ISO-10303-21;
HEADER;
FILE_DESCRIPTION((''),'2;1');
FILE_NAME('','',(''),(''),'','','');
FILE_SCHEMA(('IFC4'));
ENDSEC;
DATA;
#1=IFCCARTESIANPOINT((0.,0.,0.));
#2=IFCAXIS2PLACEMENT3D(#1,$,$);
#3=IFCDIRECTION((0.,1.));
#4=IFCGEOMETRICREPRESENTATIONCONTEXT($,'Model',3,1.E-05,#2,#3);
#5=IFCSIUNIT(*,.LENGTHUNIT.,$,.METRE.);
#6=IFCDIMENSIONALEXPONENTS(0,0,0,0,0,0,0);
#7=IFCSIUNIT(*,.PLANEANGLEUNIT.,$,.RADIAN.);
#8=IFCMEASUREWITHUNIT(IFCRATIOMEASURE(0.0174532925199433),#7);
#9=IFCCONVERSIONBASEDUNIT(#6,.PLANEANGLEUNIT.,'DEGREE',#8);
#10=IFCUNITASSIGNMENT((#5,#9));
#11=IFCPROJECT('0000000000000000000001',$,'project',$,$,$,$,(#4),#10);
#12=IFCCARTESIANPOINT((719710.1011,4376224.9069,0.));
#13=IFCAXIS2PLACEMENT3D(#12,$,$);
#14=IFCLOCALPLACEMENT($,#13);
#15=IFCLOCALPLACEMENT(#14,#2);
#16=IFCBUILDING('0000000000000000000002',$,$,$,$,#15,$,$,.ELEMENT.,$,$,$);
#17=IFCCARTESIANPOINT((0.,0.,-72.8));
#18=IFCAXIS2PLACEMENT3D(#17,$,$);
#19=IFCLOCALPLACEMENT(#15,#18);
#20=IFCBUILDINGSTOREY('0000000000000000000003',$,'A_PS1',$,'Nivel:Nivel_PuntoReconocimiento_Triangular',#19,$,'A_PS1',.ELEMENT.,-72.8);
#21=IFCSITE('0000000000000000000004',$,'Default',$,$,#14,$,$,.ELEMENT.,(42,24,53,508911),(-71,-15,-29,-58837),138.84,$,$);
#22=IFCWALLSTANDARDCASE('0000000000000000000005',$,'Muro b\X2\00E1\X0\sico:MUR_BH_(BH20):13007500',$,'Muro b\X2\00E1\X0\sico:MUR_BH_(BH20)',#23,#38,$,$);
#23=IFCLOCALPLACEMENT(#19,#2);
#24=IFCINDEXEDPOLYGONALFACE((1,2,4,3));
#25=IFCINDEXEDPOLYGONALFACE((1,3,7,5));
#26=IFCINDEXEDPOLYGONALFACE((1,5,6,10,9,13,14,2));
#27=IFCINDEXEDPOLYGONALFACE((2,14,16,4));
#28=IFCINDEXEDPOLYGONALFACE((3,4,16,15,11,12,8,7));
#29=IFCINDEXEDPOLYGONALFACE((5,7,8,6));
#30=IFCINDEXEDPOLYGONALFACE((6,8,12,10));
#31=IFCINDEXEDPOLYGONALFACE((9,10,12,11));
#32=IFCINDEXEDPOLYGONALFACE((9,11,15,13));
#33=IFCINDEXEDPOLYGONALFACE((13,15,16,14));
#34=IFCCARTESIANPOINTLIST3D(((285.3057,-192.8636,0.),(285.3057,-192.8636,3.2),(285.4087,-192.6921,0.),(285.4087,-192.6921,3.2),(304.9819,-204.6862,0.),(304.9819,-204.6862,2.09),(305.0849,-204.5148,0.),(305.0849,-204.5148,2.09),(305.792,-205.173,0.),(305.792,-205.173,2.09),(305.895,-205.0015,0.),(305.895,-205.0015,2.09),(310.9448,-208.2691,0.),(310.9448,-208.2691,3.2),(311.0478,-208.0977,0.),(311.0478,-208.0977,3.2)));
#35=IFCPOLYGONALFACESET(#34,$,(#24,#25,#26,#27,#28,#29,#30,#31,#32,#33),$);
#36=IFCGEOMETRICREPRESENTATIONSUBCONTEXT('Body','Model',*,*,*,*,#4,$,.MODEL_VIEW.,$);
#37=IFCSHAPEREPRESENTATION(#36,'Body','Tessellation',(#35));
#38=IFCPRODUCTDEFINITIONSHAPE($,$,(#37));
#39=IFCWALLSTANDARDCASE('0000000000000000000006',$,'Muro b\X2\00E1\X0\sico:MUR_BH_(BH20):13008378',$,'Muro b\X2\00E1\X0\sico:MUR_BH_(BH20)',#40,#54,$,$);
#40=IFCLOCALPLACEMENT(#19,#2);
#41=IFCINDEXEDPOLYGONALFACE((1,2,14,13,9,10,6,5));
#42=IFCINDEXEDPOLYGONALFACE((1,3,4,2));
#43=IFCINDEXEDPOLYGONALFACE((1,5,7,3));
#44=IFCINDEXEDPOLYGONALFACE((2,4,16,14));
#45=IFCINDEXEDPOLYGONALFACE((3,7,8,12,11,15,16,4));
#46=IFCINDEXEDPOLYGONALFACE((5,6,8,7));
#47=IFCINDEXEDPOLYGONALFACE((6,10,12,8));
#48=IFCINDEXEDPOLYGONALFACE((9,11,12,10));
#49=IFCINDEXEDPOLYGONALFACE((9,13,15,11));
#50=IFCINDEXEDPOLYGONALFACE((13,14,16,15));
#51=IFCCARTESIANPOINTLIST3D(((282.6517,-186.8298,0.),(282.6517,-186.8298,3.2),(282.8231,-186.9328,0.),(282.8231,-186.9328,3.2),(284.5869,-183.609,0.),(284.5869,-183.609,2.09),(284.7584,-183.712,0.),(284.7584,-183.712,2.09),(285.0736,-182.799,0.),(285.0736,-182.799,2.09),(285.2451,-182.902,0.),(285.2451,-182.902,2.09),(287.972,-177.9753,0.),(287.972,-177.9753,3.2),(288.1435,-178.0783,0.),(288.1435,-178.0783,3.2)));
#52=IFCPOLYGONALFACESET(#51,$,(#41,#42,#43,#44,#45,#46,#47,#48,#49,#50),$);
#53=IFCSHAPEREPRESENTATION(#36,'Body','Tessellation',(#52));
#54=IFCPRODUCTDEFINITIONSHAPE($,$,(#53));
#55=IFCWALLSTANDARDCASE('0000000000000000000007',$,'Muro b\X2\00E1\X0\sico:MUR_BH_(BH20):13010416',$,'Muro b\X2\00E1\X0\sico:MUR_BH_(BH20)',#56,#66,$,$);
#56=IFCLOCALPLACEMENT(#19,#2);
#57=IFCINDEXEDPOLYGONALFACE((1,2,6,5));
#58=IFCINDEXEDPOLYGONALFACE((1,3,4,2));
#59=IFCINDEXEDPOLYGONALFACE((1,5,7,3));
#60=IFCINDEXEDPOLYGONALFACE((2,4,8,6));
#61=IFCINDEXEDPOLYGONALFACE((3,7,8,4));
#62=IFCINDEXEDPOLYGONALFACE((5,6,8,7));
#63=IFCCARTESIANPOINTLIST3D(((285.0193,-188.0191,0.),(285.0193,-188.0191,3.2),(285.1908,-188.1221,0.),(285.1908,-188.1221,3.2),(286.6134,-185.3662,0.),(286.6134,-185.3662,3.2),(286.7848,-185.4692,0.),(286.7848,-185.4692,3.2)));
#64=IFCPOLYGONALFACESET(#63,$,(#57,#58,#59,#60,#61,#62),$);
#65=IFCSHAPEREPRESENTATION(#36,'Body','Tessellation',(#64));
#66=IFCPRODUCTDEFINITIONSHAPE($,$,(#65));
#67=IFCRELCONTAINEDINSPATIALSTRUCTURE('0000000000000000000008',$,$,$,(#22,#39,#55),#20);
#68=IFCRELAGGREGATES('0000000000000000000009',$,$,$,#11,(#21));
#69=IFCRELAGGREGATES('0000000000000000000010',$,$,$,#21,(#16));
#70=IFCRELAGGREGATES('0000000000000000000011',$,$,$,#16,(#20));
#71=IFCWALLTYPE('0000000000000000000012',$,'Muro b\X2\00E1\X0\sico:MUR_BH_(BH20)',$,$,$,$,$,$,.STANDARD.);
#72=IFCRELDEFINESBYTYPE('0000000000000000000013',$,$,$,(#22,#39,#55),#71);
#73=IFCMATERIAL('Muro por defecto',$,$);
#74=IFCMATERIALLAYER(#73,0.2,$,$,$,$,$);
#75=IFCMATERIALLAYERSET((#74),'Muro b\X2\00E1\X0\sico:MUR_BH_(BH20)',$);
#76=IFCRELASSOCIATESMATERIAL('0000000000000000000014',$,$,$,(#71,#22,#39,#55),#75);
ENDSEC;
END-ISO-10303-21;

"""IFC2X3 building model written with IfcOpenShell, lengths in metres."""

from ifc_helpers import new_model, entity, si_unit, converted_unit, direction, frame, frame_2d, origin, place, context, subcontext, project, spatial, rectangle, extrude, material, layer, layer_set, layer_usage, type_object, element, save


model = new_model("IFC2X3")

# Units and contexts
model_context = context("Model", 3, precision=1e-05, world=origin(), true_north=direction((0.0, 1.0)))
body_context = subcontext(model_context, "Body", "Model", "MODEL_VIEW")
ifc_project = project(units=[si_unit("LENGTHUNIT", "METRE"), converted_unit("PLANEANGLEUNIT", "DEGREE", entity("IfcRatioMeasure", 0.0174532925199433), si_unit("PLANEANGLEUNIT", "RADIAN"), dimensions=[0, 0, 0, 0, 0, 0, 0])], contexts=[model_context])

# Site, building, storey
site_placement = place(None, frame((719710.1011, 4376224.9069, 0.0)))
site = spatial("IfcSite", under=ifc_project, at=site_placement, Name="Default", CompositionType="ELEMENT", RefLatitude=(42, 24, 53, 508911), RefLongitude=(-71, -15, -29, -58837), RefElevation=138.84)
building_placement = place(site_placement, origin())
building = spatial("IfcBuilding", under=site, at=building_placement, CompositionType="ELEMENT")
storey_placement = place(building_placement, frame((0.0, 0.0, -72.8)))
storey = spatial("IfcBuildingStorey", under=building, at=storey_placement, Name="A_PS1", ObjectType="Nivel:Nivel_PuntoReconocimiento_Triangular", LongName="A_PS1", CompositionType="ELEMENT", Elevation=-72.8)

# Shared definitions
ifc_material_1 = material(Name="Muro por defecto")
ifc_layer_1 = layer(ifc_material_1, 0.2)
ifc_layer_set_1 = layer_set([ifc_layer_1], Name="Muro básico:MUR_BH_(BH20)")
wall_type = type_object("IfcWallType", Name="Muro básico:MUR_BH_(BH20)", PredefinedType="STANDARD", material=ifc_layer_set_1)

# Walls, openings
ifc_layer_usage_1 = layer_usage(ifc_layer_set_1, "AXIS2", "NEGATIVE", 0.1)
wall_1_placement = place(storey_placement, frame((285.3572, -192.7779, 0.0), z_axis=(0.0, 0.0, 1.0), x_axis=(0.857167, -0.515038, 0.0)))
wall_1 = element("IfcWallStandardCase", 1, at=wall_1_placement, inside=storey, type_object=wall_type, material=ifc_layer_usage_1, Name="Muro básico:MUR_BH_(BH20):13007500", ObjectType="Muro básico:MUR_BH_(BH20)", context=body_context, shape_type="SweptSolid", body=[
    extrude(rectangle(XDim=29.9114, YDim=0.2, at=frame_2d((14.9557, 0.0), x_axis=(-1.0, 0.0))), origin(), (0.0, 0.0, 1.0), 3.2),
])
opening_1_placement = place(wall_1_placement, frame((-343.8868, 18.273, 0.0), z_axis=(0.0, 0.0, 1.0), x_axis=(0.857167, 0.515038, 0.0)))
element("IfcOpeningElement", 2, at=opening_1_placement, cuts=wall_1, ObjectType="Opening", context=body_context, shape_type="SweptSolid", body=[
    extrude(rectangle(XDim=2.09, YDim=0.945, at=frame_2d((0.0, 0.0), x_axis=(0.0, 1.0))), frame((305.3869, -204.9296, 1.045), z_axis=(0.515038, 0.857167, 0.0), x_axis=(0.857167, -0.515038, 0.0)), (0.0, 0.0, 1.0), 0.2),
])
ifc_layer_usage_2 = layer_usage(ifc_layer_set_1, "AXIS2", "NEGATIVE", 0.1)
wall_2_placement = place(storey_placement, frame((282.7374, -186.8813, 0.0), z_axis=(0.0, 0.0, 1.0), x_axis=(0.515038, 0.857167, 0.0)))
wall_2 = element("IfcWallStandardCase", 3, at=wall_2_placement, inside=storey, type_object=wall_type, material=ifc_layer_usage_2, Name="Muro básico:MUR_BH_(BH20):13008378", ObjectType="Muro básico:MUR_BH_(BH20)", context=body_context, shape_type="SweptSolid", body=[
    extrude(rectangle(XDim=10.33, YDim=0.2, at=frame_2d((5.165, 0.0), x_axis=(-1.0, 0.0))), origin(), (0.0, 0.0, 1.0), 3.2),
])
opening_2_placement = place(wall_2_placement, frame((14.568, 338.6042, 0.0), z_axis=(0.0, 0.0, 1.0), x_axis=(0.515038, -0.857167, 0.0)))
element("IfcOpeningElement", 4, at=opening_2_placement, cuts=wall_2, ObjectType="Opening", context=body_context, shape_type="SweptSolid", body=[
    extrude(rectangle(XDim=2.09, YDim=0.945, at=frame_2d((0.0, 0.0), x_axis=(0.0, 1.0))), frame((285.0017, -183.307, 1.045), z_axis=(-0.857167, 0.515038, 0.0), x_axis=(0.515038, 0.857167, 0.0)), (0.0, 0.0, 1.0), 0.2),
])

# Wall
ifc_layer_usage_3 = layer_usage(ifc_layer_set_1, "AXIS2", "NEGATIVE", 0.1)
wall_3_placement = place(storey_placement, frame((285.105, -188.0706, 0.0), z_axis=(0.0, 0.0, 1.0), x_axis=(0.515038, 0.857167, 0.0)))
element("IfcWallStandardCase", 5, at=wall_3_placement, inside=storey, type_object=wall_type, material=ifc_layer_usage_3, Name="Muro básico:MUR_BH_(BH20):13010416", ObjectType="Muro básico:MUR_BH_(BH20)", context=body_context, shape_type="SweptSolid", body=[
    extrude(rectangle(XDim=3.095, YDim=0.2, at=frame_2d((1.5475, 0.0), x_axis=(-1.0, 0.0))), origin(), (0.0, 0.0, 1.0), 3.2),
])

save(model, "model.ifc")
